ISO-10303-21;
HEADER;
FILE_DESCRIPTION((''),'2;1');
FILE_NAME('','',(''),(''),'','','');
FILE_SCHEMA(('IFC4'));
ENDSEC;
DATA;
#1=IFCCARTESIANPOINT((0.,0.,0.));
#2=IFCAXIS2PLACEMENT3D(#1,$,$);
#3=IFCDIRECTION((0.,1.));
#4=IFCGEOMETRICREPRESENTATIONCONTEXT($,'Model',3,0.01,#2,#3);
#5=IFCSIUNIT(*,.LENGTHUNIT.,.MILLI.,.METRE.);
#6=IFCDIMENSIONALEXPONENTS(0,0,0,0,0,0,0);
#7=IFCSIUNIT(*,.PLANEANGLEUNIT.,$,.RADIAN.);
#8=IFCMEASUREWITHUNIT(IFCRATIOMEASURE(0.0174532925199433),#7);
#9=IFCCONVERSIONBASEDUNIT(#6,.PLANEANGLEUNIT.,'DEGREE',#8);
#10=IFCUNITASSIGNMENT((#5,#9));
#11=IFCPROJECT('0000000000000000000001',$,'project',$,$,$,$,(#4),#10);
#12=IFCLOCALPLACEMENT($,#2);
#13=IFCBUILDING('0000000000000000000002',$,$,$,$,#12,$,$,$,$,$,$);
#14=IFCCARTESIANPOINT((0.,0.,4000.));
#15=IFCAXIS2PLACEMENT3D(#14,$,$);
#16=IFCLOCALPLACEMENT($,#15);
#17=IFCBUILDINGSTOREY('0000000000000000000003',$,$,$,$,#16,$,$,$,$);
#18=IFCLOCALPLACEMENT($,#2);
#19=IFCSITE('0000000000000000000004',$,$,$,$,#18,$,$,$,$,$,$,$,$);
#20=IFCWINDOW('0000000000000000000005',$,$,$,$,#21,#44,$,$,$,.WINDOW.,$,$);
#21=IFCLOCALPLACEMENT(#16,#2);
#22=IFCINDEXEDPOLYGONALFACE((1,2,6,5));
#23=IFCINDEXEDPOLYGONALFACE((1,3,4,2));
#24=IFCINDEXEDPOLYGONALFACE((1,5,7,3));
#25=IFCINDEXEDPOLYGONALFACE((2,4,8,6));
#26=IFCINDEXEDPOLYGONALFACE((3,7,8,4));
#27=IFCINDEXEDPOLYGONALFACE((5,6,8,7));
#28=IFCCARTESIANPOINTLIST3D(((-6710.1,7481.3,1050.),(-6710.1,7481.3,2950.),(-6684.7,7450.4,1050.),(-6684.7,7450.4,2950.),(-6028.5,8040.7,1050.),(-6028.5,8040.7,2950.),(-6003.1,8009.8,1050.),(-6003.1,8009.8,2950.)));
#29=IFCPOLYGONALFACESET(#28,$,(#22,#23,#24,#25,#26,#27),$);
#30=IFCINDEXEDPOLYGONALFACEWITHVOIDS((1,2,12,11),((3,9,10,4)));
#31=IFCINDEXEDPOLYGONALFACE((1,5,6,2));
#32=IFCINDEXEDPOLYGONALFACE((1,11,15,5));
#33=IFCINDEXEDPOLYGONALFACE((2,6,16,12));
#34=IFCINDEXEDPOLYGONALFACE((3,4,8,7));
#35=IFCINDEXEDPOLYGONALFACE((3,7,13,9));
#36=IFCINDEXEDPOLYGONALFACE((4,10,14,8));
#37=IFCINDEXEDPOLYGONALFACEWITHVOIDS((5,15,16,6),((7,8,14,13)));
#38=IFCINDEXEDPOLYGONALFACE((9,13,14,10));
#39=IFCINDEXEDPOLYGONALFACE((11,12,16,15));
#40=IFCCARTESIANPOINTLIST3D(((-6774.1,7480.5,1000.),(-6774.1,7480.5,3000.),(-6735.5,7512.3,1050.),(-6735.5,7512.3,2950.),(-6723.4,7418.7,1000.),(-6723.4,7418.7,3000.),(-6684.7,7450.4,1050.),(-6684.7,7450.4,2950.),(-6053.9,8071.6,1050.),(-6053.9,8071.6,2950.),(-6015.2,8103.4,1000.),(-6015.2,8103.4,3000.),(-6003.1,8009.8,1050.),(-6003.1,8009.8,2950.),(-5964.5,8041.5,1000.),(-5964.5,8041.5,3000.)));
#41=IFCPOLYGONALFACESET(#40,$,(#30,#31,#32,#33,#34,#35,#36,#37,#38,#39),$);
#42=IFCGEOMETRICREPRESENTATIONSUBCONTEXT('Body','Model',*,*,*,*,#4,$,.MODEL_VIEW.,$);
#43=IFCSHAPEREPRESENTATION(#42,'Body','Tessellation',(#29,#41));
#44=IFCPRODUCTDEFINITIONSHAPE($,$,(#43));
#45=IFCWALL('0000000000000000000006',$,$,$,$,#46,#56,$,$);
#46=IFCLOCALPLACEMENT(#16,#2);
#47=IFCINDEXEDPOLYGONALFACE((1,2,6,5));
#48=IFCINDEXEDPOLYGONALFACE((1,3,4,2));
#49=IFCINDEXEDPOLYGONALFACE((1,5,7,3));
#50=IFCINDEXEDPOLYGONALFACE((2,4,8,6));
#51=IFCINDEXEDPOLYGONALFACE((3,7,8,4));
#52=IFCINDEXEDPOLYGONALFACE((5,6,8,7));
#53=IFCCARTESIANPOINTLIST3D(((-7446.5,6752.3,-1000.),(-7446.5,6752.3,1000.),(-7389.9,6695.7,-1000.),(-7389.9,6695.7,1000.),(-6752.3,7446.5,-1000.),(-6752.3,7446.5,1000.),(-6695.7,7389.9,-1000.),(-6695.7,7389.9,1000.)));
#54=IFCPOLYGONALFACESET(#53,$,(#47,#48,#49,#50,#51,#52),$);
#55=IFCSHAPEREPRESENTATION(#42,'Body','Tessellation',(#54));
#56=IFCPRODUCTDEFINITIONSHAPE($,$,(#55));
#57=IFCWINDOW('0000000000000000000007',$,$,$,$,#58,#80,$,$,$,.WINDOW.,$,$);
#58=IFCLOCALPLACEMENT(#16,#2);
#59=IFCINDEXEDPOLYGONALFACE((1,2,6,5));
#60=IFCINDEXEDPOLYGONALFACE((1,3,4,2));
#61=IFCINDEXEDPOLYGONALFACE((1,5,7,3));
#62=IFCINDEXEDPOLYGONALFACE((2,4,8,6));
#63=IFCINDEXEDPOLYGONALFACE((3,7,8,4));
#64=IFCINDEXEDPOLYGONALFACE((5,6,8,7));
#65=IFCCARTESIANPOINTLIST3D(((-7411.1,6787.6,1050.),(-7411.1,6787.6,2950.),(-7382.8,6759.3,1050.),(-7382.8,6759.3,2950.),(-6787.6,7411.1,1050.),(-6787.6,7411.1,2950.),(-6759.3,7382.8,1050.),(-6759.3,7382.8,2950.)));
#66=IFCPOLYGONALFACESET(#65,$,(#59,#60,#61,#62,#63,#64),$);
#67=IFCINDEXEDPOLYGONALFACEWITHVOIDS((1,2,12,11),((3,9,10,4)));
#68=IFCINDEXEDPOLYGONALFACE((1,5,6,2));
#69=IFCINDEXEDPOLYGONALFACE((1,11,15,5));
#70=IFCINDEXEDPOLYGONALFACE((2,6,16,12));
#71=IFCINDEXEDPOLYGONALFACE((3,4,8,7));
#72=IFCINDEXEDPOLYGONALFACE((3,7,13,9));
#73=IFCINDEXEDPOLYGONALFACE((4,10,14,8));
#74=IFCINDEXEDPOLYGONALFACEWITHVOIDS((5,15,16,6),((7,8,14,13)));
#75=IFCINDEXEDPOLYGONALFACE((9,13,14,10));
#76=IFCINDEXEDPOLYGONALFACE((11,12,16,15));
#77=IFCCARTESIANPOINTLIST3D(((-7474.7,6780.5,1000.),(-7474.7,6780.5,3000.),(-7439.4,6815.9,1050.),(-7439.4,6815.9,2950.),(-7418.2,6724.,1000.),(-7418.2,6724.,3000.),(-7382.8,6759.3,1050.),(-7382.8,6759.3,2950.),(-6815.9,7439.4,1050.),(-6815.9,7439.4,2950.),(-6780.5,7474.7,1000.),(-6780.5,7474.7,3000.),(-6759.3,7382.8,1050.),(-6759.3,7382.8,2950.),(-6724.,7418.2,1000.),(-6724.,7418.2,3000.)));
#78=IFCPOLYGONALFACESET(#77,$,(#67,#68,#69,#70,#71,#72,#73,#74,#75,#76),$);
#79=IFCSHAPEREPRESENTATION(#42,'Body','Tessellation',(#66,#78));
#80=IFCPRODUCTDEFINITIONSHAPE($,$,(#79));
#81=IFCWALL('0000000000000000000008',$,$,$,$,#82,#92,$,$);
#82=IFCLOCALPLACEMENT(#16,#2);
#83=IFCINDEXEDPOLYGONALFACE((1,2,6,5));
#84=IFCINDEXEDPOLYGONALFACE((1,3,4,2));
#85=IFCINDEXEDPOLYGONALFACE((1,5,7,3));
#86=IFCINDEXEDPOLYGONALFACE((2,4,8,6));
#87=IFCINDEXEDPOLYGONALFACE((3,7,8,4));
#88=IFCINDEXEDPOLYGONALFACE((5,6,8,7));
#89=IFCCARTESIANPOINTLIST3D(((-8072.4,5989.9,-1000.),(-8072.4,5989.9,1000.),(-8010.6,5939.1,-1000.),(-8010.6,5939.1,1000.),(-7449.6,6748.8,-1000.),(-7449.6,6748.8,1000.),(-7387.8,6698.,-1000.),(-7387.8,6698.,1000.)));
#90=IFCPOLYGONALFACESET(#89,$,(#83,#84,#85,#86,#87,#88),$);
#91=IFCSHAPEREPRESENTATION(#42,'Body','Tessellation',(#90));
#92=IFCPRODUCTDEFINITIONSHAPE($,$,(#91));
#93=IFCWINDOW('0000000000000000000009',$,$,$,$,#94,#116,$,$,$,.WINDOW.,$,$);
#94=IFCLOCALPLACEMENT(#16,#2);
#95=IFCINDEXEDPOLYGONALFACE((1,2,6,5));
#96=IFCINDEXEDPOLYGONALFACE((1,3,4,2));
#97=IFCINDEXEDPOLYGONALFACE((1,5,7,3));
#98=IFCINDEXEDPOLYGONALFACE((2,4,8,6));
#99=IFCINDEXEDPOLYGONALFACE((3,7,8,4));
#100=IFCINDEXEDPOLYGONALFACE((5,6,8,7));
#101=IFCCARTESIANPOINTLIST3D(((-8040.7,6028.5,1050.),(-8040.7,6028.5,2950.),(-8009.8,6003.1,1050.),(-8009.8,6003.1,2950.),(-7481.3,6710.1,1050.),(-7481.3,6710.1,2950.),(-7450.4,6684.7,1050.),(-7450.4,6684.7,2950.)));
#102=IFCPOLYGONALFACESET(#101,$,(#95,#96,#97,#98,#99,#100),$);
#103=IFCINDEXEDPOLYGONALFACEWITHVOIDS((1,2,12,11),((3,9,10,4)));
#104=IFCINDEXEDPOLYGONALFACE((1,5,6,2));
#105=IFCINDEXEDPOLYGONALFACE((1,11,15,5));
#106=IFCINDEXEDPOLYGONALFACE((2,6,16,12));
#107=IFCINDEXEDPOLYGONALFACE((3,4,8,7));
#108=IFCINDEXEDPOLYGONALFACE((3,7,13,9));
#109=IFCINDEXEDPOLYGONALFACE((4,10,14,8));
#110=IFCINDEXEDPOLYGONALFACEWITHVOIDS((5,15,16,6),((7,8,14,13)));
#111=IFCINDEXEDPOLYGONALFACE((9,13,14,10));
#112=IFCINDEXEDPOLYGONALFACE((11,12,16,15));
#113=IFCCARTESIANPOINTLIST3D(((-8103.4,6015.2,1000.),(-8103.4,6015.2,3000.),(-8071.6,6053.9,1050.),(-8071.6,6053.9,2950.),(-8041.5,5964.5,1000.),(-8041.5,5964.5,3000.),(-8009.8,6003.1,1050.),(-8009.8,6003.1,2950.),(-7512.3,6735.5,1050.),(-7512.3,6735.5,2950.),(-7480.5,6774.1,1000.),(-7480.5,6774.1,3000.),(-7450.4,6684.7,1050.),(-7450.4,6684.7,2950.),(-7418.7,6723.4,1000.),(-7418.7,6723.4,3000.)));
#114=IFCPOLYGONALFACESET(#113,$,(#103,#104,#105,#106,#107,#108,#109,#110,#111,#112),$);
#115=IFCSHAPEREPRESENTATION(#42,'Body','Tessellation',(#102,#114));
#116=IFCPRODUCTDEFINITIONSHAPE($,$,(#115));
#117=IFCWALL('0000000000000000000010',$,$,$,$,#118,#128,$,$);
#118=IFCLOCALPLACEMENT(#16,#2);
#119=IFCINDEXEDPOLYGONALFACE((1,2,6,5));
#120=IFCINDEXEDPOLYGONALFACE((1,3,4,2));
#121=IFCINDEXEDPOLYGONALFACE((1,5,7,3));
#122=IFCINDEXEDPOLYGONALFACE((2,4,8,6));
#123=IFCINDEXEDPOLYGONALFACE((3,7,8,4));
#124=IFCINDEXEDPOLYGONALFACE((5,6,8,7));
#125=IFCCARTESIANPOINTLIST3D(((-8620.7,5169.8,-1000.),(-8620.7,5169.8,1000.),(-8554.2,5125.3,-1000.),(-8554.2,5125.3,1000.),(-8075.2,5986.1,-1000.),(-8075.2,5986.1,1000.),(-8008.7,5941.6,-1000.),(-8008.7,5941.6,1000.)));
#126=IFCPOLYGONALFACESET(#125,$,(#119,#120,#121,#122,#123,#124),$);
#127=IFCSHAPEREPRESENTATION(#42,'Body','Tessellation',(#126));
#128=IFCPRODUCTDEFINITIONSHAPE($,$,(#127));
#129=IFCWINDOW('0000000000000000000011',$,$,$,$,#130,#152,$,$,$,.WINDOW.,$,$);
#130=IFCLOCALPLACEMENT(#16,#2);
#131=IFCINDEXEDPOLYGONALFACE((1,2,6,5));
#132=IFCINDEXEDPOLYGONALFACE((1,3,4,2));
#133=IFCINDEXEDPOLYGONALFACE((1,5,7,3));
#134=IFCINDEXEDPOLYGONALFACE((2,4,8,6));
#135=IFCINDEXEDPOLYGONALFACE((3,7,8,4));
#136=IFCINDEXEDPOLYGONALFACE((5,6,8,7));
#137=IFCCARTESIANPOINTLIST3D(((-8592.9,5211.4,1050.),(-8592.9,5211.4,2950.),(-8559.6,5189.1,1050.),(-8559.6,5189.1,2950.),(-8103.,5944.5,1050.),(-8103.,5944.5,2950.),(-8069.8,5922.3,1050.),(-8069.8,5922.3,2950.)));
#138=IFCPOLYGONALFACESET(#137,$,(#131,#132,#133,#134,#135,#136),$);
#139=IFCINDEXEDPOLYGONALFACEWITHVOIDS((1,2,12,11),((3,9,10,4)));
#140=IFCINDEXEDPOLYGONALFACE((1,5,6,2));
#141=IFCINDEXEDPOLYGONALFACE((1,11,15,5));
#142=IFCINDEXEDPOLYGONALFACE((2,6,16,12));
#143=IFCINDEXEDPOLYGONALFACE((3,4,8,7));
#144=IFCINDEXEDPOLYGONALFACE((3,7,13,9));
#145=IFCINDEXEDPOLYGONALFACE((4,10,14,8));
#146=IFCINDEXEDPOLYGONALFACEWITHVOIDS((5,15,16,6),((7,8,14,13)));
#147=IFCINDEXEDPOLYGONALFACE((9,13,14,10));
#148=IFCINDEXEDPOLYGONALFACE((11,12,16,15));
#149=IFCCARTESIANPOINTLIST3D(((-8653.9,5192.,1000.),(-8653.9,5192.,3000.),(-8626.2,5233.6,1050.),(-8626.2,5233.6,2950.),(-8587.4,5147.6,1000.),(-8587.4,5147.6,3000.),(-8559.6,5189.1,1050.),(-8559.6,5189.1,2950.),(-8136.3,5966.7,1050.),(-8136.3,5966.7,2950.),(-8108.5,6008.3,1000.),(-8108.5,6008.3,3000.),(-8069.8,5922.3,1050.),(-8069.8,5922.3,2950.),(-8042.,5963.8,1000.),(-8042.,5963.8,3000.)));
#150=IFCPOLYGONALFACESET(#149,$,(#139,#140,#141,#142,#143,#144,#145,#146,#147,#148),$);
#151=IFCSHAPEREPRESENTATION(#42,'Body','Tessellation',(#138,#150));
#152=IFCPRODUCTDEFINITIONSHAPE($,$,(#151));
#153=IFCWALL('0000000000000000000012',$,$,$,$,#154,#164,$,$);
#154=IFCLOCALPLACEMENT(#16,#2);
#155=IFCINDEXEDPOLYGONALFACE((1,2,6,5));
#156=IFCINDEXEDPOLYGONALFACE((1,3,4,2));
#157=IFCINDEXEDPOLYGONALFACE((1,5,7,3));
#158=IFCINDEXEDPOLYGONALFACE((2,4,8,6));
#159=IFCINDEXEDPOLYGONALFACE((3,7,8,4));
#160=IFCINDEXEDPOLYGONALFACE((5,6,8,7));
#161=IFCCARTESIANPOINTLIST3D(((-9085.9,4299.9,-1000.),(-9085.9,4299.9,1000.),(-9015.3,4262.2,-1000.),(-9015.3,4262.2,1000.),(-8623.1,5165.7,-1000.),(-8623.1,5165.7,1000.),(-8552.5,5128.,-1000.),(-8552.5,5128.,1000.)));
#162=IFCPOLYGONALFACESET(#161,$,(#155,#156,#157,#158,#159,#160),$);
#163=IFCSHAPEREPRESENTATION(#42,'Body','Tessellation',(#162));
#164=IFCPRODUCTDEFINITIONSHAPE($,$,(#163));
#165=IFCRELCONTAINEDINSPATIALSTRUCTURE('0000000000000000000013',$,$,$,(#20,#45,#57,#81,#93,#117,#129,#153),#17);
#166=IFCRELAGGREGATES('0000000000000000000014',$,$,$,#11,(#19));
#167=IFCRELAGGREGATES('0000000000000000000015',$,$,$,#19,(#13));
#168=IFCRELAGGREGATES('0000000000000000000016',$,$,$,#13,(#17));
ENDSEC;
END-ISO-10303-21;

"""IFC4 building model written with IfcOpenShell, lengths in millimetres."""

from ifc_helpers import new_model, entity, si_unit, converted_unit, direction, frame, origin, origin_2d, place, context, subcontext, project, spatial, rectangle, extrude, element, save


model = new_model("IFC4")

# Units and contexts
model_context = context("Model", 3, precision=0.01, world=origin(), true_north=direction((0.0, 1.0)))
body_context = subcontext(model_context, "Body", "Model", "MODEL_VIEW")
ifc_project = project(units=[si_unit("LENGTHUNIT", "METRE", prefix="MILLI"), converted_unit("PLANEANGLEUNIT", "DEGREE", entity("IfcRatioMeasure", 0.0174532925199433), si_unit("PLANEANGLEUNIT", "RADIAN"), dimensions=[0, 0, 0, 0, 0, 0, 0])], contexts=[model_context])

# Site, building, storey
site_placement = place(None, origin())
site = spatial("IfcSite", under=ifc_project, at=site_placement)
building_placement = place(None, origin())
building = spatial("IfcBuilding", under=site, at=building_placement)
storey_placement = place(None, frame((0.0, 0.0, 4000.0)))
storey = spatial("IfcBuildingStorey", under=building, at=storey_placement)

# Shared definitions
cartesian_point_1 = entity("IfcCartesianPoint", [-440.9, -950.0])
shared_polyline = entity("IfcPolyline", [cartesian_point_1, entity("IfcCartesianPoint", [-440.9, 950.0]), entity("IfcCartesianPoint", [-440.9, 950.0]), entity("IfcCartesianPoint", [440.9, 950.0]), entity("IfcCartesianPoint", [440.9, 950.0]), entity("IfcCartesianPoint", [440.9, -950.0]), entity("IfcCartesianPoint", [440.9, -950.0]), entity("IfcCartesianPoint", [-440.9, -950.0]), cartesian_point_1])

# Window
window_1_placement = place(storey_placement, frame((-6343.9, 7730.1, 2000.0), z_axis=(0.0, 0.0, 1.0), x_axis=(-7730.104749, -6343.932579, 0.0)))
cartesian_point_2 = entity("IfcCartesianPoint", [-490.9, -1000.0])
element("IfcWindow", 1, at=window_1_placement, inside=storey, PredefinedType="WINDOW", context=body_context, shape_type="SweptSolid", body=[
    entity("IfcExtrudedAreaSolid", entity("IfcArbitraryClosedProfileDef", "AREA", None, shared_polyline), entity("IfcAxis2Placement3D", entity("IfcCartesianPoint", [0.0, 0.0, 0.0]), entity("IfcDirection", [0.0, -1.0, 0.0]), entity("IfcDirection", [1.0, 0.0, 0.0])), entity("IfcDirection", [0.0, 0.0, 1.0]), 40.0),
    entity("IfcExtrudedAreaSolid", entity("IfcArbitraryProfileDefWithVoids", "AREA", None, entity("IfcPolyline", [cartesian_point_2, entity("IfcCartesianPoint", [-490.9, 1000.0]), entity("IfcCartesianPoint", [-490.9, 1000.0]), entity("IfcCartesianPoint", [490.9, 1000.0]), entity("IfcCartesianPoint", [490.9, 1000.0]), entity("IfcCartesianPoint", [490.9, -1000.0]), entity("IfcCartesianPoint", [490.9, -1000.0]), entity("IfcCartesianPoint", [-490.9, -1000.0]), cartesian_point_2]), [shared_polyline]), entity("IfcAxis2Placement3D", entity("IfcCartesianPoint", [0.0, 0.0, 0.0]), entity("IfcDirection", [0.0, -1.0, 0.0]), entity("IfcDirection", [1.0, 0.0, 0.0])), entity("IfcDirection", [0.0, 0.0, 1.0]), 80.0),
])

# Wall
wall_1_placement = place(storey_placement, frame((-7071.1, 7071.1, -1000.0), z_axis=(0.0, 0.0, 1.0), x_axis=(-7071.06777, -7071.067854, 0.0)))
element("IfcWall", 2, at=wall_1_placement, inside=storey, context=body_context, shape_type="SweptSolid", body=[
    extrude(rectangle(XDim=981.7, YDim=80.0, at=origin_2d()), origin(), (0.0, 0.0, 1.0), 2000.0),
])

# Window
window_2_placement = place(storey_placement, frame((-7071.1, 7071.1, 2000.0), z_axis=(0.0, 0.0, 1.0), x_axis=(-7071.06777, -7071.067854, 0.0)))
cartesian_point_3 = entity("IfcCartesianPoint", [-490.9, -1000.0])
element("IfcWindow", 3, at=window_2_placement, inside=storey, PredefinedType="WINDOW", context=body_context, shape_type="SweptSolid", body=[
    entity("IfcExtrudedAreaSolid", entity("IfcArbitraryClosedProfileDef", "AREA", None, shared_polyline), entity("IfcAxis2Placement3D", entity("IfcCartesianPoint", [0.0, 0.0, 0.0]), entity("IfcDirection", [0.0, -1.0, 0.0]), entity("IfcDirection", [1.0, 0.0, 0.0])), entity("IfcDirection", [0.0, 0.0, 1.0]), 40.0),
    entity("IfcExtrudedAreaSolid", entity("IfcArbitraryProfileDefWithVoids", "AREA", None, entity("IfcPolyline", [cartesian_point_3, entity("IfcCartesianPoint", [-490.9, 1000.0]), entity("IfcCartesianPoint", [-490.9, 1000.0]), entity("IfcCartesianPoint", [490.9, 1000.0]), entity("IfcCartesianPoint", [490.9, 1000.0]), entity("IfcCartesianPoint", [490.9, -1000.0]), entity("IfcCartesianPoint", [490.9, -1000.0]), entity("IfcCartesianPoint", [-490.9, -1000.0]), cartesian_point_3]), [shared_polyline]), entity("IfcAxis2Placement3D", entity("IfcCartesianPoint", [0.0, 0.0, 0.0]), entity("IfcDirection", [0.0, -1.0, 0.0]), entity("IfcDirection", [1.0, 0.0, 0.0])), entity("IfcDirection", [0.0, 0.0, 1.0]), 80.0),
])

# Wall
wall_2_placement = place(storey_placement, frame((-7730.1, 6343.9, -1000.0), z_axis=(0.0, 0.0, 1.0), x_axis=(-6343.932486, -7730.104825, 0.0)))
element("IfcWall", 4, at=wall_2_placement, inside=storey, context=body_context, shape_type="SweptSolid", body=[
    extrude(rectangle(XDim=981.7, YDim=80.0, at=origin_2d()), origin(), (0.0, 0.0, 1.0), 2000.0),
])

# Window
window_3_placement = place(storey_placement, frame((-7730.1, 6343.9, 2000.0), z_axis=(0.0, 0.0, 1.0), x_axis=(-6343.932486, -7730.104825, 0.0)))
cartesian_point_4 = entity("IfcCartesianPoint", [-490.9, -1000.0])
element("IfcWindow", 5, at=window_3_placement, inside=storey, PredefinedType="WINDOW", context=body_context, shape_type="SweptSolid", body=[
    entity("IfcExtrudedAreaSolid", entity("IfcArbitraryClosedProfileDef", "AREA", None, shared_polyline), entity("IfcAxis2Placement3D", entity("IfcCartesianPoint", [0.0, 0.0, 0.0]), entity("IfcDirection", [0.0, -1.0, 0.0]), entity("IfcDirection", [1.0, 0.0, 0.0])), entity("IfcDirection", [0.0, 0.0, 1.0]), 40.0),
    entity("IfcExtrudedAreaSolid", entity("IfcArbitraryProfileDefWithVoids", "AREA", None, entity("IfcPolyline", [cartesian_point_4, entity("IfcCartesianPoint", [-490.9, 1000.0]), entity("IfcCartesianPoint", [-490.9, 1000.0]), entity("IfcCartesianPoint", [490.9, 1000.0]), entity("IfcCartesianPoint", [490.9, 1000.0]), entity("IfcCartesianPoint", [490.9, -1000.0]), entity("IfcCartesianPoint", [490.9, -1000.0]), entity("IfcCartesianPoint", [-490.9, -1000.0]), cartesian_point_4]), [shared_polyline]), entity("IfcAxis2Placement3D", entity("IfcCartesianPoint", [0.0, 0.0, 0.0]), entity("IfcDirection", [0.0, -1.0, 0.0]), entity("IfcDirection", [1.0, 0.0, 0.0])), entity("IfcDirection", [0.0, 0.0, 1.0]), 80.0),
])

# Wall
wall_3_placement = place(storey_placement, frame((-8314.7, 5555.7, -1000.0), z_axis=(0.0, 0.0, 1.0), x_axis=(-5555.701616, -8314.6966, 0.0)))
element("IfcWall", 6, at=wall_3_placement, inside=storey, context=body_context, shape_type="SweptSolid", body=[
    extrude(rectangle(XDim=981.7, YDim=80.0, at=origin_2d()), origin(), (0.0, 0.0, 1.0), 2000.0),
])

# Window
window_4_placement = place(storey_placement, frame((-8314.7, 5555.7, 2000.0), z_axis=(0.0, 0.0, 1.0), x_axis=(-5555.701616, -8314.6966, 0.0)))
cartesian_point_5 = entity("IfcCartesianPoint", [-490.9, -1000.0])
element("IfcWindow", 7, at=window_4_placement, inside=storey, PredefinedType="WINDOW", context=body_context, shape_type="SweptSolid", body=[
    entity("IfcExtrudedAreaSolid", entity("IfcArbitraryClosedProfileDef", "AREA", None, shared_polyline), entity("IfcAxis2Placement3D", entity("IfcCartesianPoint", [0.0, 0.0, 0.0]), entity("IfcDirection", [0.0, -1.0, 0.0]), entity("IfcDirection", [1.0, 0.0, 0.0])), entity("IfcDirection", [0.0, 0.0, 1.0]), 40.0),
    entity("IfcExtrudedAreaSolid", entity("IfcArbitraryProfileDefWithVoids", "AREA", None, entity("IfcPolyline", [cartesian_point_5, entity("IfcCartesianPoint", [-490.9, 1000.0]), entity("IfcCartesianPoint", [-490.9, 1000.0]), entity("IfcCartesianPoint", [490.9, 1000.0]), entity("IfcCartesianPoint", [490.9, 1000.0]), entity("IfcCartesianPoint", [490.9, -1000.0]), entity("IfcCartesianPoint", [490.9, -1000.0]), entity("IfcCartesianPoint", [-490.9, -1000.0]), cartesian_point_5]), [shared_polyline]), entity("IfcAxis2Placement3D", entity("IfcCartesianPoint", [0.0, 0.0, 0.0]), entity("IfcDirection", [0.0, -1.0, 0.0]), entity("IfcDirection", [1.0, 0.0, 0.0])), entity("IfcDirection", [0.0, 0.0, 1.0]), 80.0),
])

# Wall
wall_4_placement = place(storey_placement, frame((-8819.2, 4714.0, -1000.0), z_axis=(0.0, 0.0, 1.0), x_axis=(-4713.96836, -8819.212113, 0.0)))
element("IfcWall", 8, at=wall_4_placement, inside=storey, context=body_context, shape_type="SweptSolid", body=[
    extrude(rectangle(XDim=981.7, YDim=80.0, at=origin_2d()), origin(), (0.0, 0.0, 1.0), 2000.0),
])

save(model, "model.ifc")
